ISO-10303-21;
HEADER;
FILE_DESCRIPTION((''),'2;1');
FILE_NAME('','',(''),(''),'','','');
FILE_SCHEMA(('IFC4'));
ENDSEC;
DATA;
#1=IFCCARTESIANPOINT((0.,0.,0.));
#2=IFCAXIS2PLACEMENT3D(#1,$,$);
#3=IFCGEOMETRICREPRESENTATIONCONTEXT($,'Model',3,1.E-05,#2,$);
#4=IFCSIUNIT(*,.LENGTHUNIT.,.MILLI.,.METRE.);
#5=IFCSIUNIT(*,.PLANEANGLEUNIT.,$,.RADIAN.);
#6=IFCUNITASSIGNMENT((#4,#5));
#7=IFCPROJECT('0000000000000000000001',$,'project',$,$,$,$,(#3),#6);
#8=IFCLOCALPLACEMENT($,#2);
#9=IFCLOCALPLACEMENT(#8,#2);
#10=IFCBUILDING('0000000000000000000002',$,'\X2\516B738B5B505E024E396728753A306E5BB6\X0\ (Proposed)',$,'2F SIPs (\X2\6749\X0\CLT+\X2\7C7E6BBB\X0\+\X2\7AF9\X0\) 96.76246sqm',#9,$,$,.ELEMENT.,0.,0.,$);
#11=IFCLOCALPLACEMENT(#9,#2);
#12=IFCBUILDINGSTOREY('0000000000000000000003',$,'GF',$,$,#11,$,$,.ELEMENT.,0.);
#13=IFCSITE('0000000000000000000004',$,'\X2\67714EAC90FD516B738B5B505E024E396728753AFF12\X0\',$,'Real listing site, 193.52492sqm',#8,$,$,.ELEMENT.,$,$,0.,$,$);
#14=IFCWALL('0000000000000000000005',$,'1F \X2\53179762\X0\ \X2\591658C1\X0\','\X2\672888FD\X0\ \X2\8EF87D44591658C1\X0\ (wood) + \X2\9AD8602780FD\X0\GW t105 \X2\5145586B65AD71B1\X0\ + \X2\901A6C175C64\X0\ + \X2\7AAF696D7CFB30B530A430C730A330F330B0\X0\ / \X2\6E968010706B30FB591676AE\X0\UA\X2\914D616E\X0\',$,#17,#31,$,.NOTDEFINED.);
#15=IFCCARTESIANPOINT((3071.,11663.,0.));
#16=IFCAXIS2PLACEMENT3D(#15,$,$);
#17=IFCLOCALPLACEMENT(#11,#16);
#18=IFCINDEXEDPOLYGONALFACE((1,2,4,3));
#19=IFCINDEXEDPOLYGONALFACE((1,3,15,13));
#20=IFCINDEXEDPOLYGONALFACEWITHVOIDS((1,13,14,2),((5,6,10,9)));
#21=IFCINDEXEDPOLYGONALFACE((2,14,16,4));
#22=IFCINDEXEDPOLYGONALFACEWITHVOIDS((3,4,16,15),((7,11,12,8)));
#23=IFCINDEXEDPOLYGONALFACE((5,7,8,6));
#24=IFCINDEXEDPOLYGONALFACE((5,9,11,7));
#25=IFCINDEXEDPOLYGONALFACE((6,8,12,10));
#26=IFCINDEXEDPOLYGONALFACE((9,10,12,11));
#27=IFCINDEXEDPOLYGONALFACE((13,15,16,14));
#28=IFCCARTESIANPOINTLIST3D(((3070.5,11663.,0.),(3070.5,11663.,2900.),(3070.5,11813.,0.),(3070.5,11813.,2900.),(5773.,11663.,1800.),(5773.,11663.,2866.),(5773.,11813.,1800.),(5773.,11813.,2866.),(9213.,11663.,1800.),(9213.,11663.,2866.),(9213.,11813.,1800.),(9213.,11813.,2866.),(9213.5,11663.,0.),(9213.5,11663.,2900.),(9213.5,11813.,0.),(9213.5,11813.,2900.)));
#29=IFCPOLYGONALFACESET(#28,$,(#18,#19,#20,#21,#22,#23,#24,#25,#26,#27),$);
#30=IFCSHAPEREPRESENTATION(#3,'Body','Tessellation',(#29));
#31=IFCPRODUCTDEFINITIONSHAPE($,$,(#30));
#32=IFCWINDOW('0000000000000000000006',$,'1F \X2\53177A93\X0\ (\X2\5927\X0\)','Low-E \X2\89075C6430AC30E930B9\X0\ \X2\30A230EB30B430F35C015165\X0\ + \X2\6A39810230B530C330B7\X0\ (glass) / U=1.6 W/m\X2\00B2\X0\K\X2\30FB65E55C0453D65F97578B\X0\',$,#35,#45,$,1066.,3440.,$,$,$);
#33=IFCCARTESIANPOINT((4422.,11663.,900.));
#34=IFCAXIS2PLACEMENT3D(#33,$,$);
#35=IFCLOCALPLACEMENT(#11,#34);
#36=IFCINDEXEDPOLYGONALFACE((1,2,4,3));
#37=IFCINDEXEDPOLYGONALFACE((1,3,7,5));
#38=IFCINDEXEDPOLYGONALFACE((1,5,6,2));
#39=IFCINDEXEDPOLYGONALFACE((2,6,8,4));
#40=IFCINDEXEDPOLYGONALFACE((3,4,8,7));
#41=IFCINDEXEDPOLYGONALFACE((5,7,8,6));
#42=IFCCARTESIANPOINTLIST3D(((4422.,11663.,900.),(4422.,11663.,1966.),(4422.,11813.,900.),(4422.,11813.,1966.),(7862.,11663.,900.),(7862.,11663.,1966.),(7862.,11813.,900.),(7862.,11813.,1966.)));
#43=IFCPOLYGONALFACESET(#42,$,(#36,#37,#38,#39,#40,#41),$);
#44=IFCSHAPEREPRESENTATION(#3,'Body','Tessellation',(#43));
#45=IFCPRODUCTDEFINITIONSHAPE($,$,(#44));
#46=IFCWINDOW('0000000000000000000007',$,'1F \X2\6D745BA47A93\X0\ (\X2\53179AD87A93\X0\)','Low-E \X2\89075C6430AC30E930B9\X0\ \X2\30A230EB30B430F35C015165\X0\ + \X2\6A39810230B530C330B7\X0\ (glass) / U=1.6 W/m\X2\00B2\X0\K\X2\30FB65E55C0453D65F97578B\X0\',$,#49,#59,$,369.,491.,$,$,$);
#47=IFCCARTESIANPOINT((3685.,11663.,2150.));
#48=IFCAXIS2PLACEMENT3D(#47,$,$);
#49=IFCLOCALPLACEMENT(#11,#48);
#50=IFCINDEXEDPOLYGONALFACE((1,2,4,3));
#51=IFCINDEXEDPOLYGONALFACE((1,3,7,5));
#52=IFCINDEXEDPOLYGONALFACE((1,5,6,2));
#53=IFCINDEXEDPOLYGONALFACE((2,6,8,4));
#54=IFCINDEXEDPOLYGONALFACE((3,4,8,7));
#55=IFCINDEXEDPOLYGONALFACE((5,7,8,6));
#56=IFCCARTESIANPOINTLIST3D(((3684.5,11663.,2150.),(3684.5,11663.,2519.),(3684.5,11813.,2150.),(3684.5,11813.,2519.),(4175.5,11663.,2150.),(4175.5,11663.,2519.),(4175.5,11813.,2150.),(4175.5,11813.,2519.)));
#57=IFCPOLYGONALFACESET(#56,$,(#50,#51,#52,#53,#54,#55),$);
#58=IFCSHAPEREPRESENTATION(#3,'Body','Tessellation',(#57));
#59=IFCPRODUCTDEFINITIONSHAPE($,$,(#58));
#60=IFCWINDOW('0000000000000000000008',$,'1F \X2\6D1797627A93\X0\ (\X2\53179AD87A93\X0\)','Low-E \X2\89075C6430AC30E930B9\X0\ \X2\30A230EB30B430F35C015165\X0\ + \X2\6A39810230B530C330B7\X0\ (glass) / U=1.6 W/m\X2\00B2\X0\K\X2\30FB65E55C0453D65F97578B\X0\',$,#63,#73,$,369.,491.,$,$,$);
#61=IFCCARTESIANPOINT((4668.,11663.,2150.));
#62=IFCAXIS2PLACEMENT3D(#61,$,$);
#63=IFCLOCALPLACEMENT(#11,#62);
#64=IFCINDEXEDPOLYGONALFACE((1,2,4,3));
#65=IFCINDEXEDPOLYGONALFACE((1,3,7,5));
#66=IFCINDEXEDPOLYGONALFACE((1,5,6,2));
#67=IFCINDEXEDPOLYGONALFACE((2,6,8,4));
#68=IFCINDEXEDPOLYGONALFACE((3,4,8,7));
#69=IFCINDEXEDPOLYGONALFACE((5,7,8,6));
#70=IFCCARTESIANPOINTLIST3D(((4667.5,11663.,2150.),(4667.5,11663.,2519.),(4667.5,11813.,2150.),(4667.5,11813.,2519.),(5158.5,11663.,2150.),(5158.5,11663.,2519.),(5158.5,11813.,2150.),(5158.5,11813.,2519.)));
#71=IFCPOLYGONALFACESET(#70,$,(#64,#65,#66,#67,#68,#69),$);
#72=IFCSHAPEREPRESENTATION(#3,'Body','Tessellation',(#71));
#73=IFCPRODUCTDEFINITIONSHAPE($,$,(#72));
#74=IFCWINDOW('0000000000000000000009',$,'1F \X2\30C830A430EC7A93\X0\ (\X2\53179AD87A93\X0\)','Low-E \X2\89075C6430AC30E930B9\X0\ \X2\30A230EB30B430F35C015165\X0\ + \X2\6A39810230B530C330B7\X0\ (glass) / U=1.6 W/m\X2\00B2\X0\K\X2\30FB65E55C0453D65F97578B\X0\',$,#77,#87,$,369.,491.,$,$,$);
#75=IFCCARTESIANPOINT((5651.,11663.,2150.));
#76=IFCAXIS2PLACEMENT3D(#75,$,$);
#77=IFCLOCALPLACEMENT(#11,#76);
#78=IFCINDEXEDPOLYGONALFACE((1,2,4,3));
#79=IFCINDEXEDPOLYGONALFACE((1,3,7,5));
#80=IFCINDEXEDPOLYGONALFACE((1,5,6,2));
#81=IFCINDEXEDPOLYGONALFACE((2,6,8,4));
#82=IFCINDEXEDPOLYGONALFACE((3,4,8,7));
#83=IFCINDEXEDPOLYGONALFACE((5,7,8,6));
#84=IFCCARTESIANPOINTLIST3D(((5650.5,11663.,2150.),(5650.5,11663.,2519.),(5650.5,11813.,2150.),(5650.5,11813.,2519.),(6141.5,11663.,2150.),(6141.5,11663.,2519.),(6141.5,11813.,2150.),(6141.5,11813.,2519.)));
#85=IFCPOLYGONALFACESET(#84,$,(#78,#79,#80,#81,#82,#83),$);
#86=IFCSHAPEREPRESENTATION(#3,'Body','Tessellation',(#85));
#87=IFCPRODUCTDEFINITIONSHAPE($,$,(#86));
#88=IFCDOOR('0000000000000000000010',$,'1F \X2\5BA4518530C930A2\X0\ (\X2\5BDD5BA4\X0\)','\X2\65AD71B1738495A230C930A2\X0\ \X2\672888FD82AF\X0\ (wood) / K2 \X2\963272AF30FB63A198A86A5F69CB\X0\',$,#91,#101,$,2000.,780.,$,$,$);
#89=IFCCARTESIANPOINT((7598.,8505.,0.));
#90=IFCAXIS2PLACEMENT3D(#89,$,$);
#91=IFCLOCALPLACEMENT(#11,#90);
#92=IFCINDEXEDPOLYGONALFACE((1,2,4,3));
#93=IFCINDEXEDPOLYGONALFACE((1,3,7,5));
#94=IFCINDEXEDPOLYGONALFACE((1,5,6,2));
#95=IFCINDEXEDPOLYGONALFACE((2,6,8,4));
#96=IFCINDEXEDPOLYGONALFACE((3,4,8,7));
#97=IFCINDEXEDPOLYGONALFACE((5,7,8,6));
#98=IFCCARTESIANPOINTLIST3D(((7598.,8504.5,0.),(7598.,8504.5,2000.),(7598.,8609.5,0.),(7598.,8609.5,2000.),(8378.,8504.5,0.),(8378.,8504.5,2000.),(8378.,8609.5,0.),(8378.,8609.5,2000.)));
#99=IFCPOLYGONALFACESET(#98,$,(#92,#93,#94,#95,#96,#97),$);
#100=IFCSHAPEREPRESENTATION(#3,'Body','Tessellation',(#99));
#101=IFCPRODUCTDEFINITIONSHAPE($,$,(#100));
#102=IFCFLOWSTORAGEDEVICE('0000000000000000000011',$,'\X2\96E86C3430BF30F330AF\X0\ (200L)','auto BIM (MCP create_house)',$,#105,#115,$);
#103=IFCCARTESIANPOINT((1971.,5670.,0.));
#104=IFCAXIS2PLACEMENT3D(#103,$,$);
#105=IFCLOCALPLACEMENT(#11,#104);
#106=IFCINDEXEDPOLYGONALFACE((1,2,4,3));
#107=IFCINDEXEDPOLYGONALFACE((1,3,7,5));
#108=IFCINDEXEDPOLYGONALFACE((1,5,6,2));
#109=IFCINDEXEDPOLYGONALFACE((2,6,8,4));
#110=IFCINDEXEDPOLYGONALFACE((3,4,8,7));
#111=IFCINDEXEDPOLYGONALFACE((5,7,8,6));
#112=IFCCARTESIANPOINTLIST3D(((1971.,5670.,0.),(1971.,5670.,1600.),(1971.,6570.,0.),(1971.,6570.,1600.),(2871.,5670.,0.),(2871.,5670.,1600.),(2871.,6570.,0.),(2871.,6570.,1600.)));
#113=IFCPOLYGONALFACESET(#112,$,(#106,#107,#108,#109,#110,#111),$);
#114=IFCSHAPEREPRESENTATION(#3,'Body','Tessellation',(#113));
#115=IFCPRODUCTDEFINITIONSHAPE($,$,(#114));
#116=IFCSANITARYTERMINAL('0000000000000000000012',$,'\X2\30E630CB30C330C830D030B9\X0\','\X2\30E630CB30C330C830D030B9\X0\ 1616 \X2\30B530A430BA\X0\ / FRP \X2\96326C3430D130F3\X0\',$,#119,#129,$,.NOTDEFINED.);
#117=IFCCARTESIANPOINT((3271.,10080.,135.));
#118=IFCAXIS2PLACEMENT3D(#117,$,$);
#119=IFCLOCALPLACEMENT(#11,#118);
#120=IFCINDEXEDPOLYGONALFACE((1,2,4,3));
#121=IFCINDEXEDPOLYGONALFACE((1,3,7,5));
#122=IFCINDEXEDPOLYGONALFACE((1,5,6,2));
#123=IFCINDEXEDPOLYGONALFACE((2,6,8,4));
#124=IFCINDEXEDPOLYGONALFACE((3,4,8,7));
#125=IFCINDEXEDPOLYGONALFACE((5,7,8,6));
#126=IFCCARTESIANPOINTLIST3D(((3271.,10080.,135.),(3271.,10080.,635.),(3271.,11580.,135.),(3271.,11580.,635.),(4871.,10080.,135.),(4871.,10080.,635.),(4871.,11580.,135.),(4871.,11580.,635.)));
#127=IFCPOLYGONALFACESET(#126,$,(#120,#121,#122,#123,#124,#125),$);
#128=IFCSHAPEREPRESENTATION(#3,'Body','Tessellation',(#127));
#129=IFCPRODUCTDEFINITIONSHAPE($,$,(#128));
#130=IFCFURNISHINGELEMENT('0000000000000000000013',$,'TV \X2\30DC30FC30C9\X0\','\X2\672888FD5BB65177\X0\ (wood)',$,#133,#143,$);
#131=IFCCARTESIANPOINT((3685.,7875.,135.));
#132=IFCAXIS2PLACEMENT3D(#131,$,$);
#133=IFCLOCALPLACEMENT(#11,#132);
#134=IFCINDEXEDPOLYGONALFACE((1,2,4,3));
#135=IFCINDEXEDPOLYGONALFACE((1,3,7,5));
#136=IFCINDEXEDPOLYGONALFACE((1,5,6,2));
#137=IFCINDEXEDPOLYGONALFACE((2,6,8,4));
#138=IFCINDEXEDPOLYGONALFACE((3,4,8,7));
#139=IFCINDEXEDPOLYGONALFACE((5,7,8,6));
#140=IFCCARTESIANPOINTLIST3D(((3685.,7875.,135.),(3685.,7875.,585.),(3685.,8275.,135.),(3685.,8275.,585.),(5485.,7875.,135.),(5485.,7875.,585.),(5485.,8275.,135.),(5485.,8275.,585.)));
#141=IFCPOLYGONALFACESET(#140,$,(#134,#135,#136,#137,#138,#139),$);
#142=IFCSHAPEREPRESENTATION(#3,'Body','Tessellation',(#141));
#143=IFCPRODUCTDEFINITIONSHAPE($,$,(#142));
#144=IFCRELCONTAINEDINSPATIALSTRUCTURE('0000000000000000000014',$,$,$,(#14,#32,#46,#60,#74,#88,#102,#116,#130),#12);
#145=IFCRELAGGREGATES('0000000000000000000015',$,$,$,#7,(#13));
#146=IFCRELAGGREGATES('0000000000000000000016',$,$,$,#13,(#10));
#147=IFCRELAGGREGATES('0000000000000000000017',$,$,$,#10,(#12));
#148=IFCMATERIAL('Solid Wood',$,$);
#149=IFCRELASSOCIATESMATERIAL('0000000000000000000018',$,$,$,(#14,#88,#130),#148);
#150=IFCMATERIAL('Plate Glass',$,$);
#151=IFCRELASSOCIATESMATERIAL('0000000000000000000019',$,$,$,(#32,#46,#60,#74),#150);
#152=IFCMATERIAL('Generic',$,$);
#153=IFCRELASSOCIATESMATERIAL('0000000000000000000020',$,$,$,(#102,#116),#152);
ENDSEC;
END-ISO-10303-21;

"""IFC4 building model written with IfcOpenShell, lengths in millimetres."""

from ifc_helpers import new_model, si_unit, frame, frame_2d, origin, place, context, project, spatial, rectangle, extrude, material, element, fill, save


model = new_model("IFC4")

# Units and contexts
model_context = context("Model", 3, precision=1e-05, world=origin())
ifc_project = project(units=[si_unit("LENGTHUNIT", "METRE", prefix="MILLI"), si_unit("PLANEANGLEUNIT", "RADIAN")], contexts=[model_context])

# Site, building, storey
site_placement = place(None, origin())
site = spatial("IfcSite", under=ifc_project, at=site_placement, Name="東京都八王子市丹木町２", ObjectType="Real listing site, 193.52492sqm", CompositionType="ELEMENT", RefElevation=0.0)
building_placement = place(site_placement, origin())
building = spatial("IfcBuilding", under=site, at=building_placement, Name="八王子市丹木町の家 (Proposed)", ObjectType="2F SIPs (杉CLT+籾殻+竹) 96.76246sqm", CompositionType="ELEMENT", ElevationOfRefHeight=0.0, ElevationOfTerrain=0.0)
storey_placement = place(building_placement, origin())
storey = spatial("IfcBuildingStorey", under=building, at=storey_placement, Name="GF", CompositionType="ELEMENT", Elevation=0.0)

# Wall, openings, windows
ifc_material_1 = material(Name="Solid Wood")
wall_1_placement = place(storey_placement, frame((3071.0, 11663.0, 0.0)))
wall_1 = element("IfcWall", 1, at=wall_1_placement, inside=storey, material=ifc_material_1, Name="1F 北面 外壁", Description="木製 軸組外壁 (wood) + 高性能GW t105 充填断熱 + 通気層 + 窯業系サイディング / 準耐火・外皮UA配慮", PredefinedType="NOTDEFINED", context=model_context, shape_type="SweptSolid", body=[
    extrude(rectangle(XDim=6143.0, YDim=150.0, at=frame_2d((3071.0, 75.0))), frame((3071.0, 11663.0, 0.0)), (0.0, 0.0, 1.0), 2900.0),
])
opening_1_placement = place(storey_placement, frame((4422.0, 11663.0, 900.0)))
opening_1 = element("IfcOpeningElement", 2, at=opening_1_placement, cuts=wall_1, PredefinedType="NOTDEFINED", context=model_context, shape_type="SweptSolid", body=[
    extrude(rectangle(XDim=3440.0, YDim=150.0, at=frame_2d((1720.0, 75.0))), frame((4422.0, 11663.0, 900.0)), (0.0, 0.0, 1.0), 1066.0),
])
opening_2_placement = place(storey_placement, frame((3685.0, 11663.0, 2150.0)))
opening_2 = element("IfcOpeningElement", 3, at=opening_2_placement, cuts=wall_1, PredefinedType="NOTDEFINED", context=model_context, shape_type="SweptSolid", body=[
    extrude(rectangle(XDim=491.0, YDim=150.0, at=frame_2d((245.0, 75.0))), frame((3685.0, 11663.0, 2150.0)), (0.0, 0.0, 1.0), 369.0),
])
opening_3_placement = place(storey_placement, frame((4668.0, 11663.0, 2150.0)))
opening_3 = element("IfcOpeningElement", 4, at=opening_3_placement, cuts=wall_1, PredefinedType="NOTDEFINED", context=model_context, shape_type="SweptSolid", body=[
    extrude(rectangle(XDim=491.0, YDim=150.0, at=frame_2d((245.0, 75.0))), frame((4668.0, 11663.0, 2150.0)), (0.0, 0.0, 1.0), 369.0),
])
opening_4_placement = place(storey_placement, frame((5651.0, 11663.0, 2150.0)))
opening_4 = element("IfcOpeningElement", 5, at=opening_4_placement, cuts=wall_1, PredefinedType="NOTDEFINED", context=model_context, shape_type="SweptSolid", body=[
    extrude(rectangle(XDim=491.0, YDim=150.0, at=frame_2d((245.0, 75.0))), frame((5651.0, 11663.0, 2150.0)), (0.0, 0.0, 1.0), 369.0),
])
ifc_material_2 = material(Name="Plate Glass")
window_1_placement = place(storey_placement, frame((4422.0, 11663.0, 900.0)))
window_1 = element("IfcWindow", 6, at=window_1_placement, inside=storey, material=ifc_material_2, Name="1F 北窓 (大)", Description="Low-E 複層ガラス アルゴン封入 + 樹脂サッシ (glass) / U=1.6 W/m²K・日射取得型", OverallHeight=1066.0, OverallWidth=3440.0, context=model_context, shape_type="SweptSolid", body=[
    extrude(rectangle(XDim=3440.0, YDim=150.0, at=frame_2d((1720.0, 75.0))), frame((4422.0, 11663.0, 900.0)), (0.0, 0.0, 1.0), 1066.0),
])
fill(opening_1, window_1)
window_2_placement = place(storey_placement, frame((3685.0, 11663.0, 2150.0)))
window_2 = element("IfcWindow", 7, at=window_2_placement, inside=storey, material=ifc_material_2, Name="1F 浴室窓 (北高窓)", Description="Low-E 複層ガラス アルゴン封入 + 樹脂サッシ (glass) / U=1.6 W/m²K・日射取得型", OverallHeight=369.0, OverallWidth=491.0, context=model_context, shape_type="SweptSolid", body=[
    extrude(rectangle(XDim=491.0, YDim=150.0, at=frame_2d((245.0, 75.0))), frame((3685.0, 11663.0, 2150.0)), (0.0, 0.0, 1.0), 369.0),
])
fill(opening_2, window_2)
window_3_placement = place(storey_placement, frame((4668.0, 11663.0, 2150.0)))
window_3 = element("IfcWindow", 8, at=window_3_placement, inside=storey, material=ifc_material_2, Name="1F 洗面窓 (北高窓)", Description="Low-E 複層ガラス アルゴン封入 + 樹脂サッシ (glass) / U=1.6 W/m²K・日射取得型", OverallHeight=369.0, OverallWidth=491.0, context=model_context, shape_type="SweptSolid", body=[
    extrude(rectangle(XDim=491.0, YDim=150.0, at=frame_2d((245.0, 75.0))), frame((4668.0, 11663.0, 2150.0)), (0.0, 0.0, 1.0), 369.0),
])
fill(opening_3, window_3)
window_4_placement = place(storey_placement, frame((5651.0, 11663.0, 2150.0)))
window_4 = element("IfcWindow", 9, at=window_4_placement, inside=storey, material=ifc_material_2, Name="1F トイレ窓 (北高窓)", Description="Low-E 複層ガラス アルゴン封入 + 樹脂サッシ (glass) / U=1.6 W/m²K・日射取得型", OverallHeight=369.0, OverallWidth=491.0, context=model_context, shape_type="SweptSolid", body=[
    extrude(rectangle(XDim=491.0, YDim=150.0, at=frame_2d((245.0, 75.0))), frame((5651.0, 11663.0, 2150.0)), (0.0, 0.0, 1.0), 369.0),
])
fill(opening_4, window_4)

# Door
door_1_placement = place(storey_placement, frame((7598.0, 8505.0, 0.0)))
element("IfcDoor", 10, at=door_1_placement, inside=storey, material=ifc_material_1, Name="1F 室内ドア (寝室)", Description="断熱玄関ドア 木製芯 (wood) / K2 防犯・採風機構", OverallHeight=2000.0, OverallWidth=780.0, context=model_context, shape_type="SweptSolid", body=[
    extrude(rectangle(XDim=780.0, YDim=105.0, at=frame_2d((390.0, 52.0))), frame((7598.0, 8505.0, 0.0)), (0.0, 0.0, 1.0), 2000.0),
])

# Flow storage device
ifc_material_3 = material(Name="Generic")
flow_storage_device_placement = place(storey_placement, frame((1971.0, 5670.0, 0.0)))
element("IfcFlowStorageDevice", 11, at=flow_storage_device_placement, inside=storey, material=ifc_material_3, Name="雨水タンク (200L)", Description="auto BIM (MCP create_house)", context=model_context, shape_type="SweptSolid", body=[
    extrude(rectangle(XDim=900.0, YDim=900.0, at=frame_2d((450.0, 450.0))), frame((1971.0, 5670.0, 0.0)), (0.0, 0.0, 1.0), 1600.0),
])

# Sanitary terminal
sanitary_terminal_placement = place(storey_placement, frame((3271.0, 10080.0, 135.0)))
element("IfcSanitaryTerminal", 12, at=sanitary_terminal_placement, inside=storey, material=ifc_material_3, Name="ユニットバス", Description="ユニットバス 1616 サイズ / FRP 防水パン", PredefinedType="NOTDEFINED", context=model_context, shape_type="SweptSolid", body=[
    extrude(rectangle(XDim=1600.0, YDim=1500.0, at=frame_2d((800.0, 750.0))), frame((3271.0, 10080.0, 135.0)), (0.0, 0.0, 1.0), 500.0),
])

# Furnishing element
furnishing_placement = place(storey_placement, frame((3685.0, 7875.0, 135.0)))
element("IfcFurnishingElement", 13, at=furnishing_placement, inside=storey, material=ifc_material_1, Name="TV ボード", Description="木製家具 (wood)", context=model_context, shape_type="SweptSolid", body=[
    extrude(rectangle(XDim=1800.0, YDim=400.0, at=frame_2d((900.0, 200.0))), frame((3685.0, 7875.0, 135.0)), (0.0, 0.0, 1.0), 450.0),
])

save(model, "model.ifc")
